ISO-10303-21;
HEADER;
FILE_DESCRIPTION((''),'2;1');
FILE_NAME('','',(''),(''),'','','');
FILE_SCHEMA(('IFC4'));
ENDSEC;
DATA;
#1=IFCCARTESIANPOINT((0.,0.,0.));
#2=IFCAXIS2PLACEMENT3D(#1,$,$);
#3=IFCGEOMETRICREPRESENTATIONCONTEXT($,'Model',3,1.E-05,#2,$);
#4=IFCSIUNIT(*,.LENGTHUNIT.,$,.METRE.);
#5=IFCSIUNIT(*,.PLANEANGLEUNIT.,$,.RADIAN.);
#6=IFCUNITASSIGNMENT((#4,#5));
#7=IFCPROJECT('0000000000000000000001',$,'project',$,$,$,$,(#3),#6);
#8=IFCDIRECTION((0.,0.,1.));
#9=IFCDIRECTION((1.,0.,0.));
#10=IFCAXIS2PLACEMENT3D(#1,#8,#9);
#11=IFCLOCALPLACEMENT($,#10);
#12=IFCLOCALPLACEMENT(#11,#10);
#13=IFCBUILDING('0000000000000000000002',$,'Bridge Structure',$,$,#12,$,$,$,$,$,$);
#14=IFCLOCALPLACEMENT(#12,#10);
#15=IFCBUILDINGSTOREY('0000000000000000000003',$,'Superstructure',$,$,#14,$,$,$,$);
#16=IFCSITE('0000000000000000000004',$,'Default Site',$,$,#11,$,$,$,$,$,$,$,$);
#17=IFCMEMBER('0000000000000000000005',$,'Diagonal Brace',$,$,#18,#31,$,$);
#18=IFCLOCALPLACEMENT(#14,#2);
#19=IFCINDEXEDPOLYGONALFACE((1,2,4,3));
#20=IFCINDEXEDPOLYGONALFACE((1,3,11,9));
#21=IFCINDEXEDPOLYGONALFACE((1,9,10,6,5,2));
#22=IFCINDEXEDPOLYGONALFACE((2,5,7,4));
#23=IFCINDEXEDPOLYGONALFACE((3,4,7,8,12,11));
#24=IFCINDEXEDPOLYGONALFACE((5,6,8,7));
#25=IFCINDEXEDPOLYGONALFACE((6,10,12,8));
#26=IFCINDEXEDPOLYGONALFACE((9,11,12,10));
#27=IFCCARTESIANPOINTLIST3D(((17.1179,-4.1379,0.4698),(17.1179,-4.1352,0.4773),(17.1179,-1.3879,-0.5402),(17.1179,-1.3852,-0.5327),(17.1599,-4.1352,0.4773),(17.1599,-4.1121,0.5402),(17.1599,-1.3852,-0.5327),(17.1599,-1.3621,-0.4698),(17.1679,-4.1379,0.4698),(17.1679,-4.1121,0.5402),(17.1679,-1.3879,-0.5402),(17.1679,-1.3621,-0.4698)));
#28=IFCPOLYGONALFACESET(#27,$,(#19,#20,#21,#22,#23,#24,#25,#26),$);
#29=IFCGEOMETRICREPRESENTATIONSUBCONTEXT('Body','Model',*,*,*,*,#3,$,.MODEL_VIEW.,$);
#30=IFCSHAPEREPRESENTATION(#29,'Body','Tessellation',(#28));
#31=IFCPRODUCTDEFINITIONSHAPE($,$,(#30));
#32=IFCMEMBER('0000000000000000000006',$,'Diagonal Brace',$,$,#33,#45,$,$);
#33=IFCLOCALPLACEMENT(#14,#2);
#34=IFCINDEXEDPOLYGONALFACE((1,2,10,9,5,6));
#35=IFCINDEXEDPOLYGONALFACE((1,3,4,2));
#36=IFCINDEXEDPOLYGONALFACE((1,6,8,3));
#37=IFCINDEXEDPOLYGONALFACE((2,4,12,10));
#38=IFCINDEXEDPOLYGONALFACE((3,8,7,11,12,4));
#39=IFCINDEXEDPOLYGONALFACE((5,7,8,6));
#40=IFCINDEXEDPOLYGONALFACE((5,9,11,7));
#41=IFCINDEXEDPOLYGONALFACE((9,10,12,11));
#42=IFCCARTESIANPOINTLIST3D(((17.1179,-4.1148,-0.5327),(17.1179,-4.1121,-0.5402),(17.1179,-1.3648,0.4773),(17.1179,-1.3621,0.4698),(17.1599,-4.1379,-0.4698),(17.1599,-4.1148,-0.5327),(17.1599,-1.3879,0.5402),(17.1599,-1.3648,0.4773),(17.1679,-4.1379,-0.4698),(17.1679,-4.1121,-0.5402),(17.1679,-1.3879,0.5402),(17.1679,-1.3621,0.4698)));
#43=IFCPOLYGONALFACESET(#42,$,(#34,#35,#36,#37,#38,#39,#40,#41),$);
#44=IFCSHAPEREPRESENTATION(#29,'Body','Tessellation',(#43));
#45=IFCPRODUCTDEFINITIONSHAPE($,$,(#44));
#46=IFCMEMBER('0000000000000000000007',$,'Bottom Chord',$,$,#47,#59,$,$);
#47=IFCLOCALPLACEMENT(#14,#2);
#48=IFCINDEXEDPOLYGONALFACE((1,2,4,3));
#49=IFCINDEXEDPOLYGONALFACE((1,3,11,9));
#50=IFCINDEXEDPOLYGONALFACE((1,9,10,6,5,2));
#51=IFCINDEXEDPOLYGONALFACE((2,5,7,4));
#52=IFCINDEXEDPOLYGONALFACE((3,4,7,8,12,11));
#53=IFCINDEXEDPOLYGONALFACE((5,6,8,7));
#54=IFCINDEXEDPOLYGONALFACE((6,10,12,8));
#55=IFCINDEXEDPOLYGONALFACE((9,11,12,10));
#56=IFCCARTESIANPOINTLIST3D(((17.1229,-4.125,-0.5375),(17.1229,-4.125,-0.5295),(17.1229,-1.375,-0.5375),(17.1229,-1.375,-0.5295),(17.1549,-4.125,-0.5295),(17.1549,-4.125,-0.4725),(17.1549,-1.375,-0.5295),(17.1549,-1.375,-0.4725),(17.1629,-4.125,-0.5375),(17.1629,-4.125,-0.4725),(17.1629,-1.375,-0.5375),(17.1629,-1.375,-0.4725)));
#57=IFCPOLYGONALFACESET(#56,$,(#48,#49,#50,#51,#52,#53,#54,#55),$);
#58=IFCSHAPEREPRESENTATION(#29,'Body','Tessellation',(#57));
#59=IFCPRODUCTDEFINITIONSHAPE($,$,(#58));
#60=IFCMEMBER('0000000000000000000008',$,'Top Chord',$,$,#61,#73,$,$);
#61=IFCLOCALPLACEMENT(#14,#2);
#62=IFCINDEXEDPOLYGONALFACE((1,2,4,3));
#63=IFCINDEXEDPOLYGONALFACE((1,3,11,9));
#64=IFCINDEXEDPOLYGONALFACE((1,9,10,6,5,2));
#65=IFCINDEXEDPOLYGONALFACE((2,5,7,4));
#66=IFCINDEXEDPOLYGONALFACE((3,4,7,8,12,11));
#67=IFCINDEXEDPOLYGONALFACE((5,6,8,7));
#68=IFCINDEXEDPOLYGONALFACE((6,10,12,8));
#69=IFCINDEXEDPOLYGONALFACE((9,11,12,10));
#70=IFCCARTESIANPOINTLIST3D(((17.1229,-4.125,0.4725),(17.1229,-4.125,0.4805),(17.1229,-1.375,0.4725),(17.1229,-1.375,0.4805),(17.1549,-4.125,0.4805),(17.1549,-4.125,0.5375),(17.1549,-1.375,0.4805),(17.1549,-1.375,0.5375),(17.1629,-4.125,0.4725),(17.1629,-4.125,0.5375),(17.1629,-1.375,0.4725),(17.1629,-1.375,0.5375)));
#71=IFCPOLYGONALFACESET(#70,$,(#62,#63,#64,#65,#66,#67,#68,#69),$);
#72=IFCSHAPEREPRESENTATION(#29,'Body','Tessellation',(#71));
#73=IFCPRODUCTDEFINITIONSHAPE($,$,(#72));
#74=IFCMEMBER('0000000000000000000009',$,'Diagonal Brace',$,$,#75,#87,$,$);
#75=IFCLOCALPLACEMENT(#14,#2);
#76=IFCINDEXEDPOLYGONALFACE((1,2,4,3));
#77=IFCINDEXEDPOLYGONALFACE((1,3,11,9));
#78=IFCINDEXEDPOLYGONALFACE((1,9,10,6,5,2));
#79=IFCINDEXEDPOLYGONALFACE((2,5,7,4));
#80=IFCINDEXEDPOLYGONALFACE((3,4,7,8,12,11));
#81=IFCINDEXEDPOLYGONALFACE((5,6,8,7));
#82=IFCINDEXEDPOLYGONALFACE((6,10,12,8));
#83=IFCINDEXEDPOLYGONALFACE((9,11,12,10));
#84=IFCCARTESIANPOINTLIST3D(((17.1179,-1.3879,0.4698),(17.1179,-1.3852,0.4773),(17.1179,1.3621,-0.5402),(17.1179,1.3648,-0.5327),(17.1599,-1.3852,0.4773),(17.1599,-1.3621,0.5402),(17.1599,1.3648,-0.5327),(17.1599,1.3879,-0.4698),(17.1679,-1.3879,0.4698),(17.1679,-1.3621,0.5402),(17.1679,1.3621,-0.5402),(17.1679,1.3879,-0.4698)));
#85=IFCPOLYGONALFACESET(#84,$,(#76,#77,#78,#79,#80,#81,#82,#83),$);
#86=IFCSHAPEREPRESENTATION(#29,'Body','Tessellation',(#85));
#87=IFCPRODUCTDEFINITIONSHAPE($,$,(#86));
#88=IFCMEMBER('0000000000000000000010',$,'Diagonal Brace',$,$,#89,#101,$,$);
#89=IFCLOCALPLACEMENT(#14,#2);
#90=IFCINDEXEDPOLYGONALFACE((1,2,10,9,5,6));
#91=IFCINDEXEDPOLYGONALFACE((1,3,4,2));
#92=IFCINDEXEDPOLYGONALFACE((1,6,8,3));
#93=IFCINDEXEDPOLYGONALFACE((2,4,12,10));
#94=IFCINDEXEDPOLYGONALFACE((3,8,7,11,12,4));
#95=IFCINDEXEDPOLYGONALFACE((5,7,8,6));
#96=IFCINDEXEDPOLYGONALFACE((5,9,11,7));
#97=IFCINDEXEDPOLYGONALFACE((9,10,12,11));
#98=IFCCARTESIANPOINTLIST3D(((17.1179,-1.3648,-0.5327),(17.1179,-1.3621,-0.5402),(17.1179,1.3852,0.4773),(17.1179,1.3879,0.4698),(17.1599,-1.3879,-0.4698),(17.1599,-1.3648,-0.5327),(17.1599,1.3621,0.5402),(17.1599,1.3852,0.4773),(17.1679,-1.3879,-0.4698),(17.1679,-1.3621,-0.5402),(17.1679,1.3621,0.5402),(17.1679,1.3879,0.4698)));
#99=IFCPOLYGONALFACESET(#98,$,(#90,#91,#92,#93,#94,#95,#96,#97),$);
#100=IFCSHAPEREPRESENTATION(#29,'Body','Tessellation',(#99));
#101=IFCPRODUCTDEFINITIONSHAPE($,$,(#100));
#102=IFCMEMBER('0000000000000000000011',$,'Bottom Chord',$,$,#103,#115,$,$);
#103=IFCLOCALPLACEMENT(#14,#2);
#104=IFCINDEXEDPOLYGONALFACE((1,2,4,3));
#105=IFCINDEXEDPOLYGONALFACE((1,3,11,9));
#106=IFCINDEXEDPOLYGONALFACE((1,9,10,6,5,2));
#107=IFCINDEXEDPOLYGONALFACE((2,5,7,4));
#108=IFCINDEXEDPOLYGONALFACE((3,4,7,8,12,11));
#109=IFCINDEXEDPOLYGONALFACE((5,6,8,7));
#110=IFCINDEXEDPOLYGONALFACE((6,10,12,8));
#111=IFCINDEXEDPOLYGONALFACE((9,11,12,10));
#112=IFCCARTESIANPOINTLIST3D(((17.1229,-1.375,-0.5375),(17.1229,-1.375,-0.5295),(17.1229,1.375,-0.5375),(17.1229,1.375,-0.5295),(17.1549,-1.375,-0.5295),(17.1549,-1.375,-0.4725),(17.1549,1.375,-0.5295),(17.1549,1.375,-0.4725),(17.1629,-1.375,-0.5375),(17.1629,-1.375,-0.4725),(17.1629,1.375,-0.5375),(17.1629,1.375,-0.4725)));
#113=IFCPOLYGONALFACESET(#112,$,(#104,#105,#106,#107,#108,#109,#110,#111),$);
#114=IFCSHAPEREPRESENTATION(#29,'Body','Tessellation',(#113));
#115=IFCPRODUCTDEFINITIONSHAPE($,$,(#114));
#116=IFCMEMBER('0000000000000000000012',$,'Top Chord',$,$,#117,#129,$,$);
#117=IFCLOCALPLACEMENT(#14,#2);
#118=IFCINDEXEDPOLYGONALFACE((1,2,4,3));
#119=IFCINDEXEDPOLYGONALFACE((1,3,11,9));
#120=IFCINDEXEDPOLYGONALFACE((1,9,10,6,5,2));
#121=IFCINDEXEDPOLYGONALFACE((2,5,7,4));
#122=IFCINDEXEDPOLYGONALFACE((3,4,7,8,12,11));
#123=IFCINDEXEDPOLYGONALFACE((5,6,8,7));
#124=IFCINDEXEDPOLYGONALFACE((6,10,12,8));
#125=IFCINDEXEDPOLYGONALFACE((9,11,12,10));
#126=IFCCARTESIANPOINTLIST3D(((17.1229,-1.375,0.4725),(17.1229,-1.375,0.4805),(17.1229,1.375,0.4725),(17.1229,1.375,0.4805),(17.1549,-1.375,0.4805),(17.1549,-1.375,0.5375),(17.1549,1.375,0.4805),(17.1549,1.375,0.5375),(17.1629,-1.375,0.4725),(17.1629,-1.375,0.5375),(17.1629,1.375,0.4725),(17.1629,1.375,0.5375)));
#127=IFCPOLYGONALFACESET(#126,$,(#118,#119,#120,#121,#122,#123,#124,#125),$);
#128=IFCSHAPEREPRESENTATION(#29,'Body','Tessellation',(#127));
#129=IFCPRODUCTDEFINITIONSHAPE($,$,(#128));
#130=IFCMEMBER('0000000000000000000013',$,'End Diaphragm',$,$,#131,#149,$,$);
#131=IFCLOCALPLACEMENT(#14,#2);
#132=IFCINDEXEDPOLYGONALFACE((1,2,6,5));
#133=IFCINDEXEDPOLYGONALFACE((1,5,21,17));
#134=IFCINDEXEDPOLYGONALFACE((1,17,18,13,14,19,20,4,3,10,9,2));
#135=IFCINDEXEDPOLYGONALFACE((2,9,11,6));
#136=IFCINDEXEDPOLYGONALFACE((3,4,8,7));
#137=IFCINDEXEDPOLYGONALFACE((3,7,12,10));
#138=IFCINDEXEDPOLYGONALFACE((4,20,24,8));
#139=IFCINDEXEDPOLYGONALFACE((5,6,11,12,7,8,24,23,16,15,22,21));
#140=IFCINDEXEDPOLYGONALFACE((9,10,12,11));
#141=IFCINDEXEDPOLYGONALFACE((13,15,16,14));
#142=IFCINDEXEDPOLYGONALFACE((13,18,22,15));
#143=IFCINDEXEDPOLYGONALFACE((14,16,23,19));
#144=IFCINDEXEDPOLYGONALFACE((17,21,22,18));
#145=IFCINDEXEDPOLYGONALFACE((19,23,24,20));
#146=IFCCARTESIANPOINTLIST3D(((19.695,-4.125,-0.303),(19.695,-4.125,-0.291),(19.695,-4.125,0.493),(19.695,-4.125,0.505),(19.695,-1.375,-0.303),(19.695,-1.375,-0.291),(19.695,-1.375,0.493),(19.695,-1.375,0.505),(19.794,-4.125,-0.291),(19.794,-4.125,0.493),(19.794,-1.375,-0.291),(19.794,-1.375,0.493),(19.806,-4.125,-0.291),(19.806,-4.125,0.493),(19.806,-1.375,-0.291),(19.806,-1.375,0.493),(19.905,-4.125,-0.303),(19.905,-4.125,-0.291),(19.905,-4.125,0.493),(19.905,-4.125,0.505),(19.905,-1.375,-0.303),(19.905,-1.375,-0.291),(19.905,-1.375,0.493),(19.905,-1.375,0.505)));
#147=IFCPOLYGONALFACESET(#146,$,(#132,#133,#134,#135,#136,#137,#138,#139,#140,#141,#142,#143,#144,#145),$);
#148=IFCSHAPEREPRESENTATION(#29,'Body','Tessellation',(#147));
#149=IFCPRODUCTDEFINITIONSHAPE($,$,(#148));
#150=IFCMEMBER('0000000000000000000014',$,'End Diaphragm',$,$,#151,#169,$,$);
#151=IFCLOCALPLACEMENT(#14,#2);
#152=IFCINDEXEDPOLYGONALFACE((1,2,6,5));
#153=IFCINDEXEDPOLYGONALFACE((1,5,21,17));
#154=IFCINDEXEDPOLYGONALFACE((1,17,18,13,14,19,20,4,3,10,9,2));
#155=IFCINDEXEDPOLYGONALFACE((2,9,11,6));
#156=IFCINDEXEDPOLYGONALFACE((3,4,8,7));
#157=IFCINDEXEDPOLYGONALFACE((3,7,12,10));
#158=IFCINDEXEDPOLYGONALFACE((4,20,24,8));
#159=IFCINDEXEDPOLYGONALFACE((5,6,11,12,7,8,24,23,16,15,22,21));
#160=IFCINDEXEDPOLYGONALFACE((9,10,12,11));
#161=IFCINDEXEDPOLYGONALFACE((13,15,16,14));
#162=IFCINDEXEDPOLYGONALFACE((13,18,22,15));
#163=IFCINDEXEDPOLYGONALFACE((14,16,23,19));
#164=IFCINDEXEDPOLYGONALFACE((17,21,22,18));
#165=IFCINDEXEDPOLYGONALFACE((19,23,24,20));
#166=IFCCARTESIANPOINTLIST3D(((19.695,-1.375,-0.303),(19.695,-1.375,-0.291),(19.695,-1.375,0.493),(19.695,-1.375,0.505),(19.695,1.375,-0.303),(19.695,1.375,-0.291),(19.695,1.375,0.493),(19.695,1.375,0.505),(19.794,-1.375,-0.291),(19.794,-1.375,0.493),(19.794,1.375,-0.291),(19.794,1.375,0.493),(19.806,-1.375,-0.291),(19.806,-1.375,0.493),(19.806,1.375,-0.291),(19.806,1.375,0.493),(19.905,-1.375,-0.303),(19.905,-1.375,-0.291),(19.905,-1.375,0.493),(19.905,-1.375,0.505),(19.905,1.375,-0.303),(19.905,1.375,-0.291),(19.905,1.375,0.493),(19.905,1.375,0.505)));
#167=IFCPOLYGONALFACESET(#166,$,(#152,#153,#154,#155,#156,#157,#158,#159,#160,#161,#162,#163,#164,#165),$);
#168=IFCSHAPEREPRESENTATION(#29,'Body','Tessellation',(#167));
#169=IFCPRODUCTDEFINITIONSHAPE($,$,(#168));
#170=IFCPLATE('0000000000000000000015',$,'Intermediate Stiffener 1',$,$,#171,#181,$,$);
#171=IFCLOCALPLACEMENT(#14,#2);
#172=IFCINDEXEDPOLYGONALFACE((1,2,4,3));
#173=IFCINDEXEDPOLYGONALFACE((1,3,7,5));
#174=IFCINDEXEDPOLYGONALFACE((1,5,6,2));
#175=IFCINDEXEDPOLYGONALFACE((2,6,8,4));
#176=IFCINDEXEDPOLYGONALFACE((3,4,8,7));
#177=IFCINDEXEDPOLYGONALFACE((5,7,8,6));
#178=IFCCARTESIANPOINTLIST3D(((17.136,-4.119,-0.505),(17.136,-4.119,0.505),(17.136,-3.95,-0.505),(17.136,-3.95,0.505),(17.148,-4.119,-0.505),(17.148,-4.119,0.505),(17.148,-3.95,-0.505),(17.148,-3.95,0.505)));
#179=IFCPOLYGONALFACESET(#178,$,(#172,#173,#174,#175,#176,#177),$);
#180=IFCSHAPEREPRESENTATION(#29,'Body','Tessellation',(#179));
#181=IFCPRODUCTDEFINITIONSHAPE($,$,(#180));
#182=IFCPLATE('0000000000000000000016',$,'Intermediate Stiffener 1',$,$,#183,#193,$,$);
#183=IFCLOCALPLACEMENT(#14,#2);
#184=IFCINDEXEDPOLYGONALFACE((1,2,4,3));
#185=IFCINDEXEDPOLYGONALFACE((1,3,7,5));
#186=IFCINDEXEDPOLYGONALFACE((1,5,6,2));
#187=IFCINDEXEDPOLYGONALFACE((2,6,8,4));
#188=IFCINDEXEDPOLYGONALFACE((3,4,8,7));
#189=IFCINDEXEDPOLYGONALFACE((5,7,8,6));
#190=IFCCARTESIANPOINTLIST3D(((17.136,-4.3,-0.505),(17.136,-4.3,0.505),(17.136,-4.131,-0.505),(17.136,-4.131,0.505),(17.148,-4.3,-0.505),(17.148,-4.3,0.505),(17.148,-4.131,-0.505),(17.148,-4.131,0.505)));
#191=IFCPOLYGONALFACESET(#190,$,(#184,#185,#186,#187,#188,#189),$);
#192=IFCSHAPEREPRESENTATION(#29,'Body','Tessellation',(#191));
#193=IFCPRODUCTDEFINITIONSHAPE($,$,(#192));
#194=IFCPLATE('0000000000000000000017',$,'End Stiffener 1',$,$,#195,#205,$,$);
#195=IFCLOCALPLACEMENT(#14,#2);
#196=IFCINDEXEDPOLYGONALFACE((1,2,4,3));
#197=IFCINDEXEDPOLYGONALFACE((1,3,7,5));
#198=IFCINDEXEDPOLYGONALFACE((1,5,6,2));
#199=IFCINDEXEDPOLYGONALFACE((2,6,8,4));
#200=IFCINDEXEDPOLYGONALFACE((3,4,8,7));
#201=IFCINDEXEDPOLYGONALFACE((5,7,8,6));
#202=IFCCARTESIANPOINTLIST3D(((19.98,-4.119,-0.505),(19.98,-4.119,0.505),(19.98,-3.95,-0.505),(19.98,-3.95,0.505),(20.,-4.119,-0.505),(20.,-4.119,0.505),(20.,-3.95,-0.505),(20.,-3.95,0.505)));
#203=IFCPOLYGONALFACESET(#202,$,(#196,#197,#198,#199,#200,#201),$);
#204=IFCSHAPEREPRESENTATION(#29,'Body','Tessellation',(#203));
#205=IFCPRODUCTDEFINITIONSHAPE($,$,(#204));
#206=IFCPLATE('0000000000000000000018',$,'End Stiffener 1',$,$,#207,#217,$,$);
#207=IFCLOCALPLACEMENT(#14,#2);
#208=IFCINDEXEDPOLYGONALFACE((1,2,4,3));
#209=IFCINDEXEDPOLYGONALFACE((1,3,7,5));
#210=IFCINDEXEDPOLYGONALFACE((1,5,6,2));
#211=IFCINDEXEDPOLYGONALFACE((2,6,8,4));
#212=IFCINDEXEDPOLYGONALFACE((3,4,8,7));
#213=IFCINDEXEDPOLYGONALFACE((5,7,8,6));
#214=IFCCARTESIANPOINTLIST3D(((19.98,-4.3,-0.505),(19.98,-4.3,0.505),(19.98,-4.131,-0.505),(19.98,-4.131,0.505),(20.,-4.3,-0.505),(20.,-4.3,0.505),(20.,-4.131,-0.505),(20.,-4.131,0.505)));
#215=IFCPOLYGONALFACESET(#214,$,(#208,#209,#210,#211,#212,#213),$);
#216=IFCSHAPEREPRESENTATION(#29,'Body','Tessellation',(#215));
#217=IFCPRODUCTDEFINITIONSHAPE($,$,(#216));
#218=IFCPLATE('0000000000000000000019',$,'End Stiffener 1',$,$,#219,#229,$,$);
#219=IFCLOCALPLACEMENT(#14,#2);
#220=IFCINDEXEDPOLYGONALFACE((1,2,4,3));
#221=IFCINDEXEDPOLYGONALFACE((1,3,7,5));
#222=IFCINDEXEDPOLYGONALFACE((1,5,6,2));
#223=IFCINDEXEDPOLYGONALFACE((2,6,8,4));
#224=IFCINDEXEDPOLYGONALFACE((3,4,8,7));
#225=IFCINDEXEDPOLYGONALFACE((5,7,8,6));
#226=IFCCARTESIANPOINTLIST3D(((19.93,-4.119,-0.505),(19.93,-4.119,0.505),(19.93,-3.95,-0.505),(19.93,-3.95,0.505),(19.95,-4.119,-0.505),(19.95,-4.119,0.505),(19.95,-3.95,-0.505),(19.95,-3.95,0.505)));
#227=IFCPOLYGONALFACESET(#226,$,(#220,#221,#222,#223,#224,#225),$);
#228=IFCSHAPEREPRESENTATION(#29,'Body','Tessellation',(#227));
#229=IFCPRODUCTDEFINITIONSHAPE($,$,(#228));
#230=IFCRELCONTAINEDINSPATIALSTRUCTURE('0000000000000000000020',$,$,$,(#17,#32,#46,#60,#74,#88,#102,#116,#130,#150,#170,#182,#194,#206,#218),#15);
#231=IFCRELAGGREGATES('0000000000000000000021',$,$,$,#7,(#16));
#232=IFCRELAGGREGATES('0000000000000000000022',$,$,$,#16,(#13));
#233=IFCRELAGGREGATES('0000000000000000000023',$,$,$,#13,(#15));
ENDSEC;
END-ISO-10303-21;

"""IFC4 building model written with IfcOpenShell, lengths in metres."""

from ifc_helpers import new_model, si_unit, frame, origin, origin_with_axes, origin_2d_with_axis, place, context, subcontext, project, spatial, rectangle, i_section, l_section, extrude, element, save


model = new_model("IFC4")

# Units and contexts
model_context = context("Model", 3, precision=1e-05, world=origin())
body_context = subcontext(model_context, "Body", "Model", "MODEL_VIEW")
ifc_project = project(units=[si_unit("LENGTHUNIT", "METRE"), si_unit("PLANEANGLEUNIT", "RADIAN")], contexts=[model_context])

# Site, building, storey
site_placement = place(None, origin_with_axes())
site = spatial("IfcSite", under=ifc_project, at=site_placement, Name="Default Site")
building_placement = place(site_placement, origin_with_axes())
building = spatial("IfcBuilding", under=site, at=building_placement, Name="Bridge Structure")
storey_placement = place(building_placement, origin_with_axes())
storey = spatial("IfcBuildingStorey", under=building, at=storey_placement, Name="Superstructure")

# Members
for number, where, z_axis, x_axis, name in (
    (1, (17.1429, -4.125, 0.505), (0.0, 0.938692, -0.344756), (-1.0, 0.0, 0.0), "Diagonal Brace"),
    (2, (17.1429, -4.125, -0.505), (0.0, 0.938692, 0.344756), (-1.0, 0.0, 0.0), "Diagonal Brace"),
):
    element("IfcMember", number, at=place(storey_placement, frame(where, z_axis=z_axis, x_axis=x_axis)), inside=storey, Name=name, context=body_context, shape_type="SweptSolid", body=[
        extrude(l_section(Depth=0.075, Width=0.05, Thickness=0.008, at=origin_2d_with_axis()), origin_with_axes(), (0.0, 0.0, 1.0), 2.9296),
    ])
for number, where, z_axis, x_axis, name in (
    (3, (17.1429, -4.125, -0.505), (0.0, 1.0, 0.0), (-1.0, 0.0, 0.0), "Bottom Chord"),
    (4, (17.1429, -4.125, 0.505), (0.0, 1.0, 0.0), (-1.0, 0.0, 0.0), "Top Chord"),
):
    element("IfcMember", number, at=place(storey_placement, frame(where, z_axis=z_axis, x_axis=x_axis)), inside=storey, Name=name, context=body_context, shape_type="SweptSolid", body=[
        extrude(l_section(Depth=0.065, Width=0.04, Thickness=0.008, at=origin_2d_with_axis()), origin_with_axes(), (0.0, 0.0, 1.0), 2.75),
    ])
for number, where, z_axis, x_axis, name in (
    (5, (17.1429, -1.375, 0.505), (0.0, 0.938692, -0.344756), (-1.0, 0.0, 0.0), "Diagonal Brace"),
    (6, (17.1429, -1.375, -0.505), (0.0, 0.938692, 0.344756), (-1.0, 0.0, 0.0), "Diagonal Brace"),
):
    element("IfcMember", number, at=place(storey_placement, frame(where, z_axis=z_axis, x_axis=x_axis)), inside=storey, Name=name, context=body_context, shape_type="SweptSolid", body=[
        extrude(l_section(Depth=0.075, Width=0.05, Thickness=0.008, at=origin_2d_with_axis()), origin_with_axes(), (0.0, 0.0, 1.0), 2.9296),
    ])
for number, where, z_axis, x_axis, name in (
    (7, (17.1429, -1.375, -0.505), (0.0, 1.0, 0.0), (-1.0, 0.0, 0.0), "Bottom Chord"),
    (8, (17.1429, -1.375, 0.505), (0.0, 1.0, 0.0), (-1.0, 0.0, 0.0), "Top Chord"),
):
    element("IfcMember", number, at=place(storey_placement, frame(where, z_axis=z_axis, x_axis=x_axis)), inside=storey, Name=name, context=body_context, shape_type="SweptSolid", body=[
        extrude(l_section(Depth=0.065, Width=0.04, Thickness=0.008, at=origin_2d_with_axis()), origin_with_axes(), (0.0, 0.0, 1.0), 2.75),
    ])
for number, where, z_axis, x_axis, name in (
    (9, (19.8, -4.125, 0.101), (0.0, 1.0, 0.0), (-1.0, 0.0, 0.0), "End Diaphragm"),
    (10, (19.8, -1.375, 0.101), (0.0, 1.0, 0.0), (-1.0, 0.0, 0.0), "End Diaphragm"),
):
    element("IfcMember", number, at=place(storey_placement, frame(where, z_axis=z_axis, x_axis=x_axis)), inside=storey, Name=name, context=body_context, shape_type="SweptSolid", body=[
        extrude(i_section(OverallWidth=0.21, OverallDepth=0.808, WebThickness=0.012, FlangeThickness=0.012, at=origin_2d_with_axis()), origin_with_axes(), (0.0, 0.0, 1.0), 2.75),
    ])

# Plates
for number, where, z_axis, x_axis, name in (
    (11, (17.142, -4.0345, -0.505), (0.0, 0.0, 1.0), (1.0, 0.0, 0.0), "Intermediate Stiffener 1"),
    (12, (17.142, -4.2155, -0.505), (0.0, 0.0, 1.0), (1.0, 0.0, 0.0), "Intermediate Stiffener 1"),
):
    element("IfcPlate", number, at=place(storey_placement, frame(where, z_axis=z_axis, x_axis=x_axis)), inside=storey, Name=name, context=body_context, shape_type="SweptSolid", body=[
        extrude(rectangle(XDim=0.012, YDim=0.169, at=origin_2d_with_axis()), origin_with_axes(), (0.0, 0.0, 1.0), 1.01),
    ])
for number, where, z_axis, x_axis, name in (
    (13, (19.99, -4.0345, -0.505), (0.0, 0.0, 1.0), (1.0, 0.0, 0.0), "End Stiffener 1"),
    (14, (19.99, -4.2155, -0.505), (0.0, 0.0, 1.0), (1.0, 0.0, 0.0), "End Stiffener 1"),
    (15, (19.94, -4.0345, -0.505), (0.0, 0.0, 1.0), (1.0, 0.0, 0.0), "End Stiffener 1"),
):
    element("IfcPlate", number, at=place(storey_placement, frame(where, z_axis=z_axis, x_axis=x_axis)), inside=storey, Name=name, context=body_context, shape_type="SweptSolid", body=[
        extrude(rectangle(XDim=0.02, YDim=0.169, at=origin_2d_with_axis()), origin_with_axes(), (0.0, 0.0, 1.0), 1.01),
    ])

save(model, "model.ifc")
